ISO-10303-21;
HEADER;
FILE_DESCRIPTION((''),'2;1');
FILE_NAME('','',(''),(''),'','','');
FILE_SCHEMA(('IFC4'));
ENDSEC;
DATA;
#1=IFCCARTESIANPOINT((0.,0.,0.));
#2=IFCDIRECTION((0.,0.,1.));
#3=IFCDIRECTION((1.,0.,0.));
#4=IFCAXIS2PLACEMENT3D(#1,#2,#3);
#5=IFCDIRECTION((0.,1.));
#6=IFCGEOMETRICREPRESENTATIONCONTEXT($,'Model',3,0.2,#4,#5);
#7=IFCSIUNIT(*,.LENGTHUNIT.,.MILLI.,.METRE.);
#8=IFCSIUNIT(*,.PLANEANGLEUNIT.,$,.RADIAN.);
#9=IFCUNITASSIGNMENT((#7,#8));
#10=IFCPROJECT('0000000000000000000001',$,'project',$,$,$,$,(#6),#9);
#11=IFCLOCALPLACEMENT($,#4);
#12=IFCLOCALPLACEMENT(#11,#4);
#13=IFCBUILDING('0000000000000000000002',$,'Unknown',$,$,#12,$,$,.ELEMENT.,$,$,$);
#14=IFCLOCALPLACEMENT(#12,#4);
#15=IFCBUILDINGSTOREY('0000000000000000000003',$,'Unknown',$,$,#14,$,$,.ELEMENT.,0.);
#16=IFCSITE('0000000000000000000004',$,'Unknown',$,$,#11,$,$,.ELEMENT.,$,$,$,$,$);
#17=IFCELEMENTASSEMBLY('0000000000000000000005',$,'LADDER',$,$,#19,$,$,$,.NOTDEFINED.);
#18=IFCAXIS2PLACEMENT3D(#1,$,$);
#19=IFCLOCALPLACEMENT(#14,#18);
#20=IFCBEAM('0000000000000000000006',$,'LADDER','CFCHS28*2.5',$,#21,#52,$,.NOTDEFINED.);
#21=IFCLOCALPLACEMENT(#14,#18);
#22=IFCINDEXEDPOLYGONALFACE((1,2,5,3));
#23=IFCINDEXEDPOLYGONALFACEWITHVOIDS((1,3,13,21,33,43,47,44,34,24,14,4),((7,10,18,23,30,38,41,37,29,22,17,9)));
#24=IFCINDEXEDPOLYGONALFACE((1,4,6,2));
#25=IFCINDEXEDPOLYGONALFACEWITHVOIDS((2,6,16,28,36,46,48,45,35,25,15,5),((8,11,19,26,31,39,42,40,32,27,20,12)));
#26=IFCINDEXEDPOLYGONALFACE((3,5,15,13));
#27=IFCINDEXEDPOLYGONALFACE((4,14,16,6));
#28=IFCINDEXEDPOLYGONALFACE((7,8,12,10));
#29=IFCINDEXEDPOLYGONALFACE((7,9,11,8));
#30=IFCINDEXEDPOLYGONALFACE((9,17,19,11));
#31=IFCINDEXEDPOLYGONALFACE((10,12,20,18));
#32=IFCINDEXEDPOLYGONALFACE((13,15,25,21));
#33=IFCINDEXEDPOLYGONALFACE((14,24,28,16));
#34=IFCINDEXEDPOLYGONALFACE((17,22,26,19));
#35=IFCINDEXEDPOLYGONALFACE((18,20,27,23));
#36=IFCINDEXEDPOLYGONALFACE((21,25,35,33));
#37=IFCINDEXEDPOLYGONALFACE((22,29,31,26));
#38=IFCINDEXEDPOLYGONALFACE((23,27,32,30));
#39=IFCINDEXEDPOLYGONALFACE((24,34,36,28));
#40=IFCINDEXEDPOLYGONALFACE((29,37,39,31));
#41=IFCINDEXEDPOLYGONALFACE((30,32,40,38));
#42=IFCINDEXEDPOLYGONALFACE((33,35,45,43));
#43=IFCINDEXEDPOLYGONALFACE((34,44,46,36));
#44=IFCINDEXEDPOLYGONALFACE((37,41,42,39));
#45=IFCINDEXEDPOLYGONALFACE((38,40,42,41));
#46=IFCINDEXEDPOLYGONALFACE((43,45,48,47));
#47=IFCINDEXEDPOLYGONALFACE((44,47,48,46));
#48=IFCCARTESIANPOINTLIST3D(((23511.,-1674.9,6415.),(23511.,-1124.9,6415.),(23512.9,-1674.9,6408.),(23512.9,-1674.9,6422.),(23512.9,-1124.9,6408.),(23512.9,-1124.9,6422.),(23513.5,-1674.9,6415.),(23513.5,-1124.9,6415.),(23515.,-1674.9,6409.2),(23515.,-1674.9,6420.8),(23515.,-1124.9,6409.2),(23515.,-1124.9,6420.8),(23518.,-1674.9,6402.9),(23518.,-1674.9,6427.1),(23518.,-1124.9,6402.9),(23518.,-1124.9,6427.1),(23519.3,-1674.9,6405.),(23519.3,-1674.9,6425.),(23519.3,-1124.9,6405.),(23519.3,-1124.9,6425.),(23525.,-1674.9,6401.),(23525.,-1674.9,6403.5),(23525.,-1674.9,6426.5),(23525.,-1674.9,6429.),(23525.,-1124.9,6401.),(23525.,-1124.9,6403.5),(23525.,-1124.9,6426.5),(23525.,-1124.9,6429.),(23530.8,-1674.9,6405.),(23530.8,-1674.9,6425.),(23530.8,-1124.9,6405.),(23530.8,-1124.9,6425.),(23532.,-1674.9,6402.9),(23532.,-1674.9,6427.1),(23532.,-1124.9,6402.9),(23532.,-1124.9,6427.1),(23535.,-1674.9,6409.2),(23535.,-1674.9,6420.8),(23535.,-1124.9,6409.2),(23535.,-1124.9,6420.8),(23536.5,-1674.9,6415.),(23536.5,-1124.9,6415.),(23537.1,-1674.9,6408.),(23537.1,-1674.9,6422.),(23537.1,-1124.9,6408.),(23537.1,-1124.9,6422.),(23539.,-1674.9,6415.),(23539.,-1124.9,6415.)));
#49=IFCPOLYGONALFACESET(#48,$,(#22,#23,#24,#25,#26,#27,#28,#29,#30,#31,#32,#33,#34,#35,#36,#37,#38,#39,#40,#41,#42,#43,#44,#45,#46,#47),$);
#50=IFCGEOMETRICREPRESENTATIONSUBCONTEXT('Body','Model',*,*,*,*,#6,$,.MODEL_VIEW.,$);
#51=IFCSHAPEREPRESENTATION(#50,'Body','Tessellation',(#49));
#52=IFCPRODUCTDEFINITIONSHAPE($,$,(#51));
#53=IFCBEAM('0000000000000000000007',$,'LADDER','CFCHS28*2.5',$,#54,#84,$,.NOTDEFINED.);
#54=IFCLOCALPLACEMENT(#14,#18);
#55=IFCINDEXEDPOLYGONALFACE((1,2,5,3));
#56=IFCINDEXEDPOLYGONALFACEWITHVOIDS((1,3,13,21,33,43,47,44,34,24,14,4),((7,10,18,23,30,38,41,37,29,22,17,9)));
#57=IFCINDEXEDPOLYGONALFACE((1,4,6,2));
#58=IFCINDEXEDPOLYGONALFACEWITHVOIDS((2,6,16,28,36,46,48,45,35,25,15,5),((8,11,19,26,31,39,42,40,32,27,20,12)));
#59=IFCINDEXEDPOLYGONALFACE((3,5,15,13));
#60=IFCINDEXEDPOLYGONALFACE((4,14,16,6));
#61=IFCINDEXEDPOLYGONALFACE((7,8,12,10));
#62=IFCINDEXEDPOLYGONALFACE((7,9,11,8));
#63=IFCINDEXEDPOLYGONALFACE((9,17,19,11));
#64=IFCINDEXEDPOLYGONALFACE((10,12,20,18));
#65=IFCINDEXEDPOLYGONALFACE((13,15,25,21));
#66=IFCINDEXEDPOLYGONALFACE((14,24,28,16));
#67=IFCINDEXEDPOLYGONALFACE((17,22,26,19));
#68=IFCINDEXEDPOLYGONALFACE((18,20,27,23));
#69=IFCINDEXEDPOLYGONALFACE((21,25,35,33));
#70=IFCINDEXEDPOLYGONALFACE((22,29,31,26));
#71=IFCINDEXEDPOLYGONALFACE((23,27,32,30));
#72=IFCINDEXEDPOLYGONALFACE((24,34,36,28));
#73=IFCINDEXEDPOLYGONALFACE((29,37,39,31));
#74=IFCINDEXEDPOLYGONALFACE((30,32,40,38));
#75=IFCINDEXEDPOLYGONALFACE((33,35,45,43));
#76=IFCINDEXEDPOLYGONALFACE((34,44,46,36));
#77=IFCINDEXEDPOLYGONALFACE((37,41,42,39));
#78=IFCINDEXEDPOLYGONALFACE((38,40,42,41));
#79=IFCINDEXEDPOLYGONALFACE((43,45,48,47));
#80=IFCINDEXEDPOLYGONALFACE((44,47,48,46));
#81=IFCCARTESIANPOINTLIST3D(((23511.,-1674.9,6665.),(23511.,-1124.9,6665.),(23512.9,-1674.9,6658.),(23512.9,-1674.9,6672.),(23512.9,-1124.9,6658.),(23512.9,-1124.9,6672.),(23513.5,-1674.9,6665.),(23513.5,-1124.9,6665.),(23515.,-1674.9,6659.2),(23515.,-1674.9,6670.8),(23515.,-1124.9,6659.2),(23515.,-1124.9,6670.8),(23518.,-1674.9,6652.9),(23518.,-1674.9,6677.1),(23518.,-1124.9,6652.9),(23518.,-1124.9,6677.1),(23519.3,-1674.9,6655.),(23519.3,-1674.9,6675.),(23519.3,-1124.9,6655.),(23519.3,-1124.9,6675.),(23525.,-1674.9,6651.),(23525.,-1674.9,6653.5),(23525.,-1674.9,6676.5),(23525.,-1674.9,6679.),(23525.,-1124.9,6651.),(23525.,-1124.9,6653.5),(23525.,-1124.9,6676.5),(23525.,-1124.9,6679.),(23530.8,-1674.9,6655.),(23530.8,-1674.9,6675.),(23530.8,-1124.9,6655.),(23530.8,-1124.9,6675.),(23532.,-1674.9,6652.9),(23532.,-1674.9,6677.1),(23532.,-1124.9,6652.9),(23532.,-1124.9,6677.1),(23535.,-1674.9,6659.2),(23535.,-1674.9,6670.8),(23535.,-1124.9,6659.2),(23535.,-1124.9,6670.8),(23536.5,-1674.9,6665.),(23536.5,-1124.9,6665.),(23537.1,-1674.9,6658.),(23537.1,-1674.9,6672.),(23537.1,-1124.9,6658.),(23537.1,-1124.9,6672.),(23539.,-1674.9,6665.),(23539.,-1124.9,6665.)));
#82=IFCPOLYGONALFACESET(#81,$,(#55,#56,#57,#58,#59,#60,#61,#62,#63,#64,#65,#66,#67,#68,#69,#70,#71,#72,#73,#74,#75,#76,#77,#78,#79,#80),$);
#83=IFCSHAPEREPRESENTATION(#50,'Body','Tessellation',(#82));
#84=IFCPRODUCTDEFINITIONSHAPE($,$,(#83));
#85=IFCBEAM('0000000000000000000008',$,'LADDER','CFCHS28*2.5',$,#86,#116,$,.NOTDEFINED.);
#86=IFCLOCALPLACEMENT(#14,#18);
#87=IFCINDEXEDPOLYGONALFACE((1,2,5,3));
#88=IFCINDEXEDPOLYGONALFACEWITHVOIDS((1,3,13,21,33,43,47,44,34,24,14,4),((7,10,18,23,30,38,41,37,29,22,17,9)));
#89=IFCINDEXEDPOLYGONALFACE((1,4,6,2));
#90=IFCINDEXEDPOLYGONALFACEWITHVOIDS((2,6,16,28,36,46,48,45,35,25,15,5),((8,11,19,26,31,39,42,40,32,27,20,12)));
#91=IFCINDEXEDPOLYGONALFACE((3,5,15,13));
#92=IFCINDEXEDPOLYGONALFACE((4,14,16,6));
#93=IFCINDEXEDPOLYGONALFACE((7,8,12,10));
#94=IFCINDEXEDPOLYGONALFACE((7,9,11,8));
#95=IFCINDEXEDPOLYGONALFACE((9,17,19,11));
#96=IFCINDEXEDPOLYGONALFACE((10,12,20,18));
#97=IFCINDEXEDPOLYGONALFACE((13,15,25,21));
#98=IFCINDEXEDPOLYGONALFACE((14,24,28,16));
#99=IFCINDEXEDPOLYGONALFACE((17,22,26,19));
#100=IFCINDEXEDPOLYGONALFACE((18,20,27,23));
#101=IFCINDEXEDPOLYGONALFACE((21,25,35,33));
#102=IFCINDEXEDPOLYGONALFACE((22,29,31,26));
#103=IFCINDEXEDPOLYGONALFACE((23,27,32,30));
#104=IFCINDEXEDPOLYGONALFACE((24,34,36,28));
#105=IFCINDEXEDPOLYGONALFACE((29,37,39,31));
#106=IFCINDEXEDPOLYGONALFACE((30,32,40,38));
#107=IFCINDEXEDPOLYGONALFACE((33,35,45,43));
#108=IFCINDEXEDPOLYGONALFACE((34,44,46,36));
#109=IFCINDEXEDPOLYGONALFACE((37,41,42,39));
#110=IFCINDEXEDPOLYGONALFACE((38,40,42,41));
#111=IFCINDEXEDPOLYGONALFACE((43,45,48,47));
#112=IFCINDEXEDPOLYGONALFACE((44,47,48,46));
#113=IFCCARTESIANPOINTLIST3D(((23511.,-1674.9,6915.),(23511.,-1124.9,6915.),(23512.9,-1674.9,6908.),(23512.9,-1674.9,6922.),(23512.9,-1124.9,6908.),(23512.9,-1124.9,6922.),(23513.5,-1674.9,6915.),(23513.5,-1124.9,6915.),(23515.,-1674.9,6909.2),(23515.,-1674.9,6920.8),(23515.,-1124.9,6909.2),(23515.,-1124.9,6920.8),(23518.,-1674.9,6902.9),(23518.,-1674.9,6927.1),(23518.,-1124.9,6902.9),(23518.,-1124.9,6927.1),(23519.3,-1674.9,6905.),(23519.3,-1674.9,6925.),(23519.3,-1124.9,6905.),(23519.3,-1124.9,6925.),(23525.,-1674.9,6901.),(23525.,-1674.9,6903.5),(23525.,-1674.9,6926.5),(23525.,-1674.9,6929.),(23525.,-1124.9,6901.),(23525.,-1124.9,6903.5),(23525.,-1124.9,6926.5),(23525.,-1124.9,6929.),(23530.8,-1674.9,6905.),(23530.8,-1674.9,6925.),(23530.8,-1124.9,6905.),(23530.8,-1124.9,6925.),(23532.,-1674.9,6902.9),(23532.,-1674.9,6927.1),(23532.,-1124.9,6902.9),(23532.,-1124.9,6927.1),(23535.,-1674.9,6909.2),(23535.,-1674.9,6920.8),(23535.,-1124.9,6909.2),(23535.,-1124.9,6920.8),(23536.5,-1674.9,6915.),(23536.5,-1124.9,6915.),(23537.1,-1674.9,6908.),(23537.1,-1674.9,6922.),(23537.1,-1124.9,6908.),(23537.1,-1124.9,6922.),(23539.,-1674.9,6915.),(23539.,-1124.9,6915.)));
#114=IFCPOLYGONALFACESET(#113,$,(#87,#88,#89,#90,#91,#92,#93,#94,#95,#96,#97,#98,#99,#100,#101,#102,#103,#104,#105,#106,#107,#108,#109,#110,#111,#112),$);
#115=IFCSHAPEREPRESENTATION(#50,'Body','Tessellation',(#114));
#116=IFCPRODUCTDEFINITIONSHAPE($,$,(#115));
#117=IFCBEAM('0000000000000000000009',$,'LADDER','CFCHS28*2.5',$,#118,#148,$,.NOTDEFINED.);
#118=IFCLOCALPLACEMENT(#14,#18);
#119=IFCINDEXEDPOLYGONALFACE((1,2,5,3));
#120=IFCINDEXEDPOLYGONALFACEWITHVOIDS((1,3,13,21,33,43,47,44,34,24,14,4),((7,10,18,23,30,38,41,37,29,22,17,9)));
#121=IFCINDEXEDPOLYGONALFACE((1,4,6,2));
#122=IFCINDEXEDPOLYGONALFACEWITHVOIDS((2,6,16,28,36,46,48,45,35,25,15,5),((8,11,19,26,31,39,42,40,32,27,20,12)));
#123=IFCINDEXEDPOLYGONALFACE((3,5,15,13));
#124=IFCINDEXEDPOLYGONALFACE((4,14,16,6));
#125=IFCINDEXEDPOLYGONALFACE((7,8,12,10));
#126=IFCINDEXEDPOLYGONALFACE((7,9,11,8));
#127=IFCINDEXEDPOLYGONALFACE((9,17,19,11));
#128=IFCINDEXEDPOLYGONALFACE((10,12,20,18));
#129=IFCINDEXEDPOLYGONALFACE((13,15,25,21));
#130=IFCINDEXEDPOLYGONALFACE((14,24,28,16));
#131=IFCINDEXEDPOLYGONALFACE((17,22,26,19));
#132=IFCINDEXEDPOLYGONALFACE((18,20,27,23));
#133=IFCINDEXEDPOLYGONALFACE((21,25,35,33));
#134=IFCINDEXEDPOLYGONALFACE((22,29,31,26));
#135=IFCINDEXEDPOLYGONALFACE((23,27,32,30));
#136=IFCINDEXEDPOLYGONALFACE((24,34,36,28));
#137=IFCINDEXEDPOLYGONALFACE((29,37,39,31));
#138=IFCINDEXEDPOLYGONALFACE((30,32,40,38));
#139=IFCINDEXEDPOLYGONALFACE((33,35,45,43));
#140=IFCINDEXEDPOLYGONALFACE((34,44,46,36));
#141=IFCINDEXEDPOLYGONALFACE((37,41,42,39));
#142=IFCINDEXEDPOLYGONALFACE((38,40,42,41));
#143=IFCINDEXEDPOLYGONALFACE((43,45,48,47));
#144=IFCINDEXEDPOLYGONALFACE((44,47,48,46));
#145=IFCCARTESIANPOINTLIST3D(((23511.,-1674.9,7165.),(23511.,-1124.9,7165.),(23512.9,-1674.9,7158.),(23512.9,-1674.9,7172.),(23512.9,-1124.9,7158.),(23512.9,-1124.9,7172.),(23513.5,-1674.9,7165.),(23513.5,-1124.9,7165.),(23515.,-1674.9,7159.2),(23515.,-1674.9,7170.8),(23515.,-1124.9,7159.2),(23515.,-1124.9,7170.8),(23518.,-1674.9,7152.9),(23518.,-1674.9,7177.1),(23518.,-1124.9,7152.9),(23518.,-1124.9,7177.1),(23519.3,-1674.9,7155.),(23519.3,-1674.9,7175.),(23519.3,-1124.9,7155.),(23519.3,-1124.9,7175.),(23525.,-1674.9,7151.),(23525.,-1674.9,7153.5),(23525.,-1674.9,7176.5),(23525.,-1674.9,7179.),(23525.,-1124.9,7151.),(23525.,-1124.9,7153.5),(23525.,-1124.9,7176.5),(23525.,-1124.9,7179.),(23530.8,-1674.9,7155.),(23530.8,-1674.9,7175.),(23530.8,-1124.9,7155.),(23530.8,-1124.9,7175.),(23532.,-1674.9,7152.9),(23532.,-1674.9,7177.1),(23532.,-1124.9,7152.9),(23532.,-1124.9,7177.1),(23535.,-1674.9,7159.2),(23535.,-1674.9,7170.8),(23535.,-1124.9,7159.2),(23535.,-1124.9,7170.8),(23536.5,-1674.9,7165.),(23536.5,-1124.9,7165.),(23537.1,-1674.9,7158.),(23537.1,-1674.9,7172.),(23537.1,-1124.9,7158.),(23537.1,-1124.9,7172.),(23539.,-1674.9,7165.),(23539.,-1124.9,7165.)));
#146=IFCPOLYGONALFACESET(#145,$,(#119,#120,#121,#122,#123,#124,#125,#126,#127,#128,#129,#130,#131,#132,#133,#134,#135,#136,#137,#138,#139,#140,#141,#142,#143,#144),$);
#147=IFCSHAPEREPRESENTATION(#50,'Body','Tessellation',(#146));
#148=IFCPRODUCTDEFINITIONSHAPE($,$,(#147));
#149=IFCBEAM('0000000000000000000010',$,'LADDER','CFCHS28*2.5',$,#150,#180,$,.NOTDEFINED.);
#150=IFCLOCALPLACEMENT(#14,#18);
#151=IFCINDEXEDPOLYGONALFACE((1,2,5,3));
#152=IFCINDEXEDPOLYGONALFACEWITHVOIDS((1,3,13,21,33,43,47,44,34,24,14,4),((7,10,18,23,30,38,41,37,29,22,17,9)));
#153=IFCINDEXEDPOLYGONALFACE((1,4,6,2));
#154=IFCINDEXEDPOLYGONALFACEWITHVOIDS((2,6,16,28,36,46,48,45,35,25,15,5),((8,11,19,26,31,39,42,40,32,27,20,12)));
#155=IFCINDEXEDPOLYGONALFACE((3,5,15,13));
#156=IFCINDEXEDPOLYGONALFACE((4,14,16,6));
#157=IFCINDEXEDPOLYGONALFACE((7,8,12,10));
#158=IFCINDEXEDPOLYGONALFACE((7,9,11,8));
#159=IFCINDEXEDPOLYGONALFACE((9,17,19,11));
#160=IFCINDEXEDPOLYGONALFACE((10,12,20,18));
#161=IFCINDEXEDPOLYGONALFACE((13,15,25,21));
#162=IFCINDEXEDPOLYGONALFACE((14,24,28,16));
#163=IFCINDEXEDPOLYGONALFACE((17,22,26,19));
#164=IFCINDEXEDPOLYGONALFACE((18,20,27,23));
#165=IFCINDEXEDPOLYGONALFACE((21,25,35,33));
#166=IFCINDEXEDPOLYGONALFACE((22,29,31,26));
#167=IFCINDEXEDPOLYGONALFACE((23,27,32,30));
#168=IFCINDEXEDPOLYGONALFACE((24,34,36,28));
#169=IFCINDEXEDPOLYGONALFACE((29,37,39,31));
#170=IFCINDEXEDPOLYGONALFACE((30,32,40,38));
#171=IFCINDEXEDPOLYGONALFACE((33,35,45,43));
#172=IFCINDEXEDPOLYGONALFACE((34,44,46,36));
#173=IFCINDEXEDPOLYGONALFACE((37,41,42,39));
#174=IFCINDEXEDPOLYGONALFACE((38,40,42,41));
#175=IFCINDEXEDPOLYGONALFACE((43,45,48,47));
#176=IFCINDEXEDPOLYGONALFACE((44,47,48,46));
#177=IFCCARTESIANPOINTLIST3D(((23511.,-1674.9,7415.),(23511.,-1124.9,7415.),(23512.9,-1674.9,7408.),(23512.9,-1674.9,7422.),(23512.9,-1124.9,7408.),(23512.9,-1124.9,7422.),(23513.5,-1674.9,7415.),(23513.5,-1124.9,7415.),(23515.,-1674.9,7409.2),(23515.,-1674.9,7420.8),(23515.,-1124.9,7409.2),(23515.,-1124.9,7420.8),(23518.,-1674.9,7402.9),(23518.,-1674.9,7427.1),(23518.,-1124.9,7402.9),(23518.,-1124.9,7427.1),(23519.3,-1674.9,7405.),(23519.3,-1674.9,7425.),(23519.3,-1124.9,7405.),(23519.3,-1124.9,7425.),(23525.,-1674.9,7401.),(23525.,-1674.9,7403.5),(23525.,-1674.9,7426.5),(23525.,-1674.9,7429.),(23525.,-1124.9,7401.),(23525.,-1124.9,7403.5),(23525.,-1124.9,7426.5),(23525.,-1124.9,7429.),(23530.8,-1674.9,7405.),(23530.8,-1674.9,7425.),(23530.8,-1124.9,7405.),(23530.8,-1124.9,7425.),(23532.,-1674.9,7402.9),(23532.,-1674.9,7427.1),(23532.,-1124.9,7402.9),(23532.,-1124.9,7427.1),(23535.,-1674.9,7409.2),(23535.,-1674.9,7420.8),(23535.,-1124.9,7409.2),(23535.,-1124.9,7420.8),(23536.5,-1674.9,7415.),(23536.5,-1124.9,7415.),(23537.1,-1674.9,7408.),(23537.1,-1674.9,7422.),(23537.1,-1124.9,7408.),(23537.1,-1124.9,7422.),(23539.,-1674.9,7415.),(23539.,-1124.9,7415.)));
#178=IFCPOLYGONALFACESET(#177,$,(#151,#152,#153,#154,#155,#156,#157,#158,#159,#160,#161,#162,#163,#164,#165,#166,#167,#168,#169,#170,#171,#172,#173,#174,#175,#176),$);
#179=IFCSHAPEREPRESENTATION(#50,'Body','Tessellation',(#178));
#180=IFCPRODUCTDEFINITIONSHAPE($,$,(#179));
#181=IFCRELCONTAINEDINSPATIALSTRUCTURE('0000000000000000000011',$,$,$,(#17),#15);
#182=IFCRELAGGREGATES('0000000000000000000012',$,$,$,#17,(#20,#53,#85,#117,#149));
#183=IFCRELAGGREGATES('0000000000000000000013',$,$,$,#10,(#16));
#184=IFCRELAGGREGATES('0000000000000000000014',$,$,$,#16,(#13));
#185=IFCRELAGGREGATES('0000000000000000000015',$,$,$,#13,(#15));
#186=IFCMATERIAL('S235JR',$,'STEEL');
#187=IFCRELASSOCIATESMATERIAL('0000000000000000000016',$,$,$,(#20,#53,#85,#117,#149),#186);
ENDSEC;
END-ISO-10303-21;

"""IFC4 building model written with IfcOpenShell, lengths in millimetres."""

from ifc_helpers import new_model, si_unit, direction, frame, origin_with_axes, place, context, subcontext, project, spatial, line, indexed_curve, outline, extrude, material, element, aggregate, save


model = new_model("IFC4")

# Units and contexts
model_context = context("Model", 3, precision=0.2, world=origin_with_axes(), true_north=direction((0.0, 1.0)))
body_context = subcontext(model_context, "Body", "Model", "MODEL_VIEW")
ifc_project = project(units=[si_unit("LENGTHUNIT", "METRE", prefix="MILLI"), si_unit("PLANEANGLEUNIT", "RADIAN")], contexts=[model_context])

# Site, building, storey
site_placement = place(None, origin_with_axes())
site = spatial("IfcSite", under=ifc_project, at=site_placement, Name="Unknown", CompositionType="ELEMENT")
building_placement = place(site_placement, origin_with_axes())
building = spatial("IfcBuilding", under=site, at=building_placement, Name="Unknown", CompositionType="ELEMENT")
storey_placement = place(building_placement, origin_with_axes())
storey = spatial("IfcBuildingStorey", under=building, at=storey_placement, Name="Unknown", CompositionType="ELEMENT", Elevation=0.0)

# Element assembly, beams
assembly_1_placement = place(storey_placement, frame((23525.0, -1699.9, 5175.0), z_axis=(0.0, 1.0, 0.0), x_axis=(0.0, 0.0, 1.0)))
assembly_1 = element("IfcElementAssembly", 1, at=assembly_1_placement, inside=storey, Name="LADDER", PredefinedType="NOTDEFINED")
ifc_material_1 = material(Name="S235JR", Category="STEEL")
beam_1_placement = place(assembly_1_placement, frame((1240.0, 0.0, 25.0), z_axis=(0.0, -1.0, 0.0), x_axis=(0.0, 0.0, 1.0)))
beam_1 = element("IfcBeam", 2, at=beam_1_placement, material=ifc_material_1, Name="LADDER", Description="CFCHS28*2.5", PredefinedType="NOTDEFINED", context=body_context, shape_type="SolidModel", body=[
    extrude(outline(indexed_curve([(14.0, 0.0), (12.1, 7.0), (7.0, 12.1), (0.0, 14.0), (-7.0, 12.1), (-12.1, 7.0), (-14.0, 0.0), (-12.1, -7.0), (-7.0, -12.1), (0.0, -14.0), (7.0, -12.1), (12.1, -7.0)], segments=[line(1, 2, 3, 4, 5, 6, 7, 8, 9, 10, 11, 12, 1)]), holes=[indexed_curve([(11.5, 0.0), (10.0, -5.8), (5.8, -10.0), (0.0, -11.5), (-5.8, -10.0), (-10.0, -5.8), (-11.5, 0.0), (-10.0, 5.8), (-5.8, 10.0), (0.0, 11.5), (5.8, 10.0), (10.0, 5.8)], segments=[line(1, 2, 3, 4, 5, 6, 7, 8, 9, 10, 11, 12, 1)])]), frame((0.0, 0.0, 0.0), z_axis=(-1.0, 0.0, 0.0), x_axis=(0.0, 0.0, 1.0)), (0.0, 0.0, -1.0), 550.0),
])
beam_2_placement = place(assembly_1_placement, frame((1490.0, 0.0, 25.0), z_axis=(0.0, -1.0, 0.0), x_axis=(0.0, 0.0, 1.0)))
beam_2 = element("IfcBeam", 3, at=beam_2_placement, material=ifc_material_1, Name="LADDER", Description="CFCHS28*2.5", PredefinedType="NOTDEFINED", context=body_context, shape_type="SolidModel", body=[
    extrude(outline(indexed_curve([(14.0, 0.0), (12.1, 7.0), (7.0, 12.1), (0.0, 14.0), (-7.0, 12.1), (-12.1, 7.0), (-14.0, 0.0), (-12.1, -7.0), (-7.0, -12.1), (0.0, -14.0), (7.0, -12.1), (12.1, -7.0)], segments=[line(1, 2, 3, 4, 5, 6, 7, 8, 9, 10, 11, 12, 1)]), holes=[indexed_curve([(11.5, 0.0), (10.0, -5.8), (5.8, -10.0), (0.0, -11.5), (-5.8, -10.0), (-10.0, -5.8), (-11.5, 0.0), (-10.0, 5.8), (-5.8, 10.0), (0.0, 11.5), (5.8, 10.0), (10.0, 5.8)], segments=[line(1, 2, 3, 4, 5, 6, 7, 8, 9, 10, 11, 12, 1)])]), frame((0.0, 0.0, 0.0), z_axis=(-1.0, 0.0, 0.0), x_axis=(0.0, 0.0, 1.0)), (0.0, 0.0, -1.0), 550.0),
])
beam_3_placement = place(assembly_1_placement, frame((1740.0, 0.0, 25.0), z_axis=(0.0, -1.0, 0.0), x_axis=(0.0, 0.0, 1.0)))
beam_3 = element("IfcBeam", 4, at=beam_3_placement, material=ifc_material_1, Name="LADDER", Description="CFCHS28*2.5", PredefinedType="NOTDEFINED", context=body_context, shape_type="SolidModel", body=[
    extrude(outline(indexed_curve([(14.0, 0.0), (12.1, 7.0), (7.0, 12.1), (0.0, 14.0), (-7.0, 12.1), (-12.1, 7.0), (-14.0, 0.0), (-12.1, -7.0), (-7.0, -12.1), (0.0, -14.0), (7.0, -12.1), (12.1, -7.0)], segments=[line(1, 2, 3, 4, 5, 6, 7, 8, 9, 10, 11, 12, 1)]), holes=[indexed_curve([(11.5, 0.0), (10.0, -5.8), (5.8, -10.0), (0.0, -11.5), (-5.8, -10.0), (-10.0, -5.8), (-11.5, 0.0), (-10.0, 5.8), (-5.8, 10.0), (0.0, 11.5), (5.8, 10.0), (10.0, 5.8)], segments=[line(1, 2, 3, 4, 5, 6, 7, 8, 9, 10, 11, 12, 1)])]), frame((0.0, 0.0, 0.0), z_axis=(-1.0, 0.0, 0.0), x_axis=(0.0, 0.0, 1.0)), (0.0, 0.0, -1.0), 550.0),
])
beam_4_placement = place(assembly_1_placement, frame((1990.0, 0.0, 25.0), z_axis=(0.0, -1.0, 0.0), x_axis=(0.0, 0.0, 1.0)))
beam_4 = element("IfcBeam", 5, at=beam_4_placement, material=ifc_material_1, Name="LADDER", Description="CFCHS28*2.5", PredefinedType="NOTDEFINED", context=body_context, shape_type="SolidModel", body=[
    extrude(outline(indexed_curve([(14.0, 0.0), (12.1, 7.0), (7.0, 12.1), (0.0, 14.0), (-7.0, 12.1), (-12.1, 7.0), (-14.0, 0.0), (-12.1, -7.0), (-7.0, -12.1), (0.0, -14.0), (7.0, -12.1), (12.1, -7.0)], segments=[line(1, 2, 3, 4, 5, 6, 7, 8, 9, 10, 11, 12, 1)]), holes=[indexed_curve([(11.5, 0.0), (10.0, -5.8), (5.8, -10.0), (0.0, -11.5), (-5.8, -10.0), (-10.0, -5.8), (-11.5, 0.0), (-10.0, 5.8), (-5.8, 10.0), (0.0, 11.5), (5.8, 10.0), (10.0, 5.8)], segments=[line(1, 2, 3, 4, 5, 6, 7, 8, 9, 10, 11, 12, 1)])]), frame((0.0, 0.0, 0.0), z_axis=(-1.0, 0.0, 0.0), x_axis=(0.0, 0.0, 1.0)), (0.0, 0.0, -1.0), 550.0),
])
beam_5_placement = place(assembly_1_placement, frame((2240.0, 0.0, 25.0), z_axis=(0.0, -1.0, 0.0), x_axis=(0.0, 0.0, 1.0)))
beam_5 = element("IfcBeam", 6, at=beam_5_placement, material=ifc_material_1, Name="LADDER", Description="CFCHS28*2.5", PredefinedType="NOTDEFINED", context=body_context, shape_type="SolidModel", body=[
    extrude(outline(indexed_curve([(14.0, 0.0), (12.1, 7.0), (7.0, 12.1), (0.0, 14.0), (-7.0, 12.1), (-12.1, 7.0), (-14.0, 0.0), (-12.1, -7.0), (-7.0, -12.1), (0.0, -14.0), (7.0, -12.1), (12.1, -7.0)], segments=[line(1, 2, 3, 4, 5, 6, 7, 8, 9, 10, 11, 12, 1)]), holes=[indexed_curve([(11.5, 0.0), (10.0, -5.8), (5.8, -10.0), (0.0, -11.5), (-5.8, -10.0), (-10.0, -5.8), (-11.5, 0.0), (-10.0, 5.8), (-5.8, 10.0), (0.0, 11.5), (5.8, 10.0), (10.0, 5.8)], segments=[line(1, 2, 3, 4, 5, 6, 7, 8, 9, 10, 11, 12, 1)])]), frame((0.0, 0.0, 0.0), z_axis=(-1.0, 0.0, 0.0), x_axis=(0.0, 0.0, 1.0)), (0.0, 0.0, -1.0), 550.0),
])

aggregate(assembly_1, [beam_1, beam_2, beam_3, beam_4, beam_5])

save(model, "model.ifc")
